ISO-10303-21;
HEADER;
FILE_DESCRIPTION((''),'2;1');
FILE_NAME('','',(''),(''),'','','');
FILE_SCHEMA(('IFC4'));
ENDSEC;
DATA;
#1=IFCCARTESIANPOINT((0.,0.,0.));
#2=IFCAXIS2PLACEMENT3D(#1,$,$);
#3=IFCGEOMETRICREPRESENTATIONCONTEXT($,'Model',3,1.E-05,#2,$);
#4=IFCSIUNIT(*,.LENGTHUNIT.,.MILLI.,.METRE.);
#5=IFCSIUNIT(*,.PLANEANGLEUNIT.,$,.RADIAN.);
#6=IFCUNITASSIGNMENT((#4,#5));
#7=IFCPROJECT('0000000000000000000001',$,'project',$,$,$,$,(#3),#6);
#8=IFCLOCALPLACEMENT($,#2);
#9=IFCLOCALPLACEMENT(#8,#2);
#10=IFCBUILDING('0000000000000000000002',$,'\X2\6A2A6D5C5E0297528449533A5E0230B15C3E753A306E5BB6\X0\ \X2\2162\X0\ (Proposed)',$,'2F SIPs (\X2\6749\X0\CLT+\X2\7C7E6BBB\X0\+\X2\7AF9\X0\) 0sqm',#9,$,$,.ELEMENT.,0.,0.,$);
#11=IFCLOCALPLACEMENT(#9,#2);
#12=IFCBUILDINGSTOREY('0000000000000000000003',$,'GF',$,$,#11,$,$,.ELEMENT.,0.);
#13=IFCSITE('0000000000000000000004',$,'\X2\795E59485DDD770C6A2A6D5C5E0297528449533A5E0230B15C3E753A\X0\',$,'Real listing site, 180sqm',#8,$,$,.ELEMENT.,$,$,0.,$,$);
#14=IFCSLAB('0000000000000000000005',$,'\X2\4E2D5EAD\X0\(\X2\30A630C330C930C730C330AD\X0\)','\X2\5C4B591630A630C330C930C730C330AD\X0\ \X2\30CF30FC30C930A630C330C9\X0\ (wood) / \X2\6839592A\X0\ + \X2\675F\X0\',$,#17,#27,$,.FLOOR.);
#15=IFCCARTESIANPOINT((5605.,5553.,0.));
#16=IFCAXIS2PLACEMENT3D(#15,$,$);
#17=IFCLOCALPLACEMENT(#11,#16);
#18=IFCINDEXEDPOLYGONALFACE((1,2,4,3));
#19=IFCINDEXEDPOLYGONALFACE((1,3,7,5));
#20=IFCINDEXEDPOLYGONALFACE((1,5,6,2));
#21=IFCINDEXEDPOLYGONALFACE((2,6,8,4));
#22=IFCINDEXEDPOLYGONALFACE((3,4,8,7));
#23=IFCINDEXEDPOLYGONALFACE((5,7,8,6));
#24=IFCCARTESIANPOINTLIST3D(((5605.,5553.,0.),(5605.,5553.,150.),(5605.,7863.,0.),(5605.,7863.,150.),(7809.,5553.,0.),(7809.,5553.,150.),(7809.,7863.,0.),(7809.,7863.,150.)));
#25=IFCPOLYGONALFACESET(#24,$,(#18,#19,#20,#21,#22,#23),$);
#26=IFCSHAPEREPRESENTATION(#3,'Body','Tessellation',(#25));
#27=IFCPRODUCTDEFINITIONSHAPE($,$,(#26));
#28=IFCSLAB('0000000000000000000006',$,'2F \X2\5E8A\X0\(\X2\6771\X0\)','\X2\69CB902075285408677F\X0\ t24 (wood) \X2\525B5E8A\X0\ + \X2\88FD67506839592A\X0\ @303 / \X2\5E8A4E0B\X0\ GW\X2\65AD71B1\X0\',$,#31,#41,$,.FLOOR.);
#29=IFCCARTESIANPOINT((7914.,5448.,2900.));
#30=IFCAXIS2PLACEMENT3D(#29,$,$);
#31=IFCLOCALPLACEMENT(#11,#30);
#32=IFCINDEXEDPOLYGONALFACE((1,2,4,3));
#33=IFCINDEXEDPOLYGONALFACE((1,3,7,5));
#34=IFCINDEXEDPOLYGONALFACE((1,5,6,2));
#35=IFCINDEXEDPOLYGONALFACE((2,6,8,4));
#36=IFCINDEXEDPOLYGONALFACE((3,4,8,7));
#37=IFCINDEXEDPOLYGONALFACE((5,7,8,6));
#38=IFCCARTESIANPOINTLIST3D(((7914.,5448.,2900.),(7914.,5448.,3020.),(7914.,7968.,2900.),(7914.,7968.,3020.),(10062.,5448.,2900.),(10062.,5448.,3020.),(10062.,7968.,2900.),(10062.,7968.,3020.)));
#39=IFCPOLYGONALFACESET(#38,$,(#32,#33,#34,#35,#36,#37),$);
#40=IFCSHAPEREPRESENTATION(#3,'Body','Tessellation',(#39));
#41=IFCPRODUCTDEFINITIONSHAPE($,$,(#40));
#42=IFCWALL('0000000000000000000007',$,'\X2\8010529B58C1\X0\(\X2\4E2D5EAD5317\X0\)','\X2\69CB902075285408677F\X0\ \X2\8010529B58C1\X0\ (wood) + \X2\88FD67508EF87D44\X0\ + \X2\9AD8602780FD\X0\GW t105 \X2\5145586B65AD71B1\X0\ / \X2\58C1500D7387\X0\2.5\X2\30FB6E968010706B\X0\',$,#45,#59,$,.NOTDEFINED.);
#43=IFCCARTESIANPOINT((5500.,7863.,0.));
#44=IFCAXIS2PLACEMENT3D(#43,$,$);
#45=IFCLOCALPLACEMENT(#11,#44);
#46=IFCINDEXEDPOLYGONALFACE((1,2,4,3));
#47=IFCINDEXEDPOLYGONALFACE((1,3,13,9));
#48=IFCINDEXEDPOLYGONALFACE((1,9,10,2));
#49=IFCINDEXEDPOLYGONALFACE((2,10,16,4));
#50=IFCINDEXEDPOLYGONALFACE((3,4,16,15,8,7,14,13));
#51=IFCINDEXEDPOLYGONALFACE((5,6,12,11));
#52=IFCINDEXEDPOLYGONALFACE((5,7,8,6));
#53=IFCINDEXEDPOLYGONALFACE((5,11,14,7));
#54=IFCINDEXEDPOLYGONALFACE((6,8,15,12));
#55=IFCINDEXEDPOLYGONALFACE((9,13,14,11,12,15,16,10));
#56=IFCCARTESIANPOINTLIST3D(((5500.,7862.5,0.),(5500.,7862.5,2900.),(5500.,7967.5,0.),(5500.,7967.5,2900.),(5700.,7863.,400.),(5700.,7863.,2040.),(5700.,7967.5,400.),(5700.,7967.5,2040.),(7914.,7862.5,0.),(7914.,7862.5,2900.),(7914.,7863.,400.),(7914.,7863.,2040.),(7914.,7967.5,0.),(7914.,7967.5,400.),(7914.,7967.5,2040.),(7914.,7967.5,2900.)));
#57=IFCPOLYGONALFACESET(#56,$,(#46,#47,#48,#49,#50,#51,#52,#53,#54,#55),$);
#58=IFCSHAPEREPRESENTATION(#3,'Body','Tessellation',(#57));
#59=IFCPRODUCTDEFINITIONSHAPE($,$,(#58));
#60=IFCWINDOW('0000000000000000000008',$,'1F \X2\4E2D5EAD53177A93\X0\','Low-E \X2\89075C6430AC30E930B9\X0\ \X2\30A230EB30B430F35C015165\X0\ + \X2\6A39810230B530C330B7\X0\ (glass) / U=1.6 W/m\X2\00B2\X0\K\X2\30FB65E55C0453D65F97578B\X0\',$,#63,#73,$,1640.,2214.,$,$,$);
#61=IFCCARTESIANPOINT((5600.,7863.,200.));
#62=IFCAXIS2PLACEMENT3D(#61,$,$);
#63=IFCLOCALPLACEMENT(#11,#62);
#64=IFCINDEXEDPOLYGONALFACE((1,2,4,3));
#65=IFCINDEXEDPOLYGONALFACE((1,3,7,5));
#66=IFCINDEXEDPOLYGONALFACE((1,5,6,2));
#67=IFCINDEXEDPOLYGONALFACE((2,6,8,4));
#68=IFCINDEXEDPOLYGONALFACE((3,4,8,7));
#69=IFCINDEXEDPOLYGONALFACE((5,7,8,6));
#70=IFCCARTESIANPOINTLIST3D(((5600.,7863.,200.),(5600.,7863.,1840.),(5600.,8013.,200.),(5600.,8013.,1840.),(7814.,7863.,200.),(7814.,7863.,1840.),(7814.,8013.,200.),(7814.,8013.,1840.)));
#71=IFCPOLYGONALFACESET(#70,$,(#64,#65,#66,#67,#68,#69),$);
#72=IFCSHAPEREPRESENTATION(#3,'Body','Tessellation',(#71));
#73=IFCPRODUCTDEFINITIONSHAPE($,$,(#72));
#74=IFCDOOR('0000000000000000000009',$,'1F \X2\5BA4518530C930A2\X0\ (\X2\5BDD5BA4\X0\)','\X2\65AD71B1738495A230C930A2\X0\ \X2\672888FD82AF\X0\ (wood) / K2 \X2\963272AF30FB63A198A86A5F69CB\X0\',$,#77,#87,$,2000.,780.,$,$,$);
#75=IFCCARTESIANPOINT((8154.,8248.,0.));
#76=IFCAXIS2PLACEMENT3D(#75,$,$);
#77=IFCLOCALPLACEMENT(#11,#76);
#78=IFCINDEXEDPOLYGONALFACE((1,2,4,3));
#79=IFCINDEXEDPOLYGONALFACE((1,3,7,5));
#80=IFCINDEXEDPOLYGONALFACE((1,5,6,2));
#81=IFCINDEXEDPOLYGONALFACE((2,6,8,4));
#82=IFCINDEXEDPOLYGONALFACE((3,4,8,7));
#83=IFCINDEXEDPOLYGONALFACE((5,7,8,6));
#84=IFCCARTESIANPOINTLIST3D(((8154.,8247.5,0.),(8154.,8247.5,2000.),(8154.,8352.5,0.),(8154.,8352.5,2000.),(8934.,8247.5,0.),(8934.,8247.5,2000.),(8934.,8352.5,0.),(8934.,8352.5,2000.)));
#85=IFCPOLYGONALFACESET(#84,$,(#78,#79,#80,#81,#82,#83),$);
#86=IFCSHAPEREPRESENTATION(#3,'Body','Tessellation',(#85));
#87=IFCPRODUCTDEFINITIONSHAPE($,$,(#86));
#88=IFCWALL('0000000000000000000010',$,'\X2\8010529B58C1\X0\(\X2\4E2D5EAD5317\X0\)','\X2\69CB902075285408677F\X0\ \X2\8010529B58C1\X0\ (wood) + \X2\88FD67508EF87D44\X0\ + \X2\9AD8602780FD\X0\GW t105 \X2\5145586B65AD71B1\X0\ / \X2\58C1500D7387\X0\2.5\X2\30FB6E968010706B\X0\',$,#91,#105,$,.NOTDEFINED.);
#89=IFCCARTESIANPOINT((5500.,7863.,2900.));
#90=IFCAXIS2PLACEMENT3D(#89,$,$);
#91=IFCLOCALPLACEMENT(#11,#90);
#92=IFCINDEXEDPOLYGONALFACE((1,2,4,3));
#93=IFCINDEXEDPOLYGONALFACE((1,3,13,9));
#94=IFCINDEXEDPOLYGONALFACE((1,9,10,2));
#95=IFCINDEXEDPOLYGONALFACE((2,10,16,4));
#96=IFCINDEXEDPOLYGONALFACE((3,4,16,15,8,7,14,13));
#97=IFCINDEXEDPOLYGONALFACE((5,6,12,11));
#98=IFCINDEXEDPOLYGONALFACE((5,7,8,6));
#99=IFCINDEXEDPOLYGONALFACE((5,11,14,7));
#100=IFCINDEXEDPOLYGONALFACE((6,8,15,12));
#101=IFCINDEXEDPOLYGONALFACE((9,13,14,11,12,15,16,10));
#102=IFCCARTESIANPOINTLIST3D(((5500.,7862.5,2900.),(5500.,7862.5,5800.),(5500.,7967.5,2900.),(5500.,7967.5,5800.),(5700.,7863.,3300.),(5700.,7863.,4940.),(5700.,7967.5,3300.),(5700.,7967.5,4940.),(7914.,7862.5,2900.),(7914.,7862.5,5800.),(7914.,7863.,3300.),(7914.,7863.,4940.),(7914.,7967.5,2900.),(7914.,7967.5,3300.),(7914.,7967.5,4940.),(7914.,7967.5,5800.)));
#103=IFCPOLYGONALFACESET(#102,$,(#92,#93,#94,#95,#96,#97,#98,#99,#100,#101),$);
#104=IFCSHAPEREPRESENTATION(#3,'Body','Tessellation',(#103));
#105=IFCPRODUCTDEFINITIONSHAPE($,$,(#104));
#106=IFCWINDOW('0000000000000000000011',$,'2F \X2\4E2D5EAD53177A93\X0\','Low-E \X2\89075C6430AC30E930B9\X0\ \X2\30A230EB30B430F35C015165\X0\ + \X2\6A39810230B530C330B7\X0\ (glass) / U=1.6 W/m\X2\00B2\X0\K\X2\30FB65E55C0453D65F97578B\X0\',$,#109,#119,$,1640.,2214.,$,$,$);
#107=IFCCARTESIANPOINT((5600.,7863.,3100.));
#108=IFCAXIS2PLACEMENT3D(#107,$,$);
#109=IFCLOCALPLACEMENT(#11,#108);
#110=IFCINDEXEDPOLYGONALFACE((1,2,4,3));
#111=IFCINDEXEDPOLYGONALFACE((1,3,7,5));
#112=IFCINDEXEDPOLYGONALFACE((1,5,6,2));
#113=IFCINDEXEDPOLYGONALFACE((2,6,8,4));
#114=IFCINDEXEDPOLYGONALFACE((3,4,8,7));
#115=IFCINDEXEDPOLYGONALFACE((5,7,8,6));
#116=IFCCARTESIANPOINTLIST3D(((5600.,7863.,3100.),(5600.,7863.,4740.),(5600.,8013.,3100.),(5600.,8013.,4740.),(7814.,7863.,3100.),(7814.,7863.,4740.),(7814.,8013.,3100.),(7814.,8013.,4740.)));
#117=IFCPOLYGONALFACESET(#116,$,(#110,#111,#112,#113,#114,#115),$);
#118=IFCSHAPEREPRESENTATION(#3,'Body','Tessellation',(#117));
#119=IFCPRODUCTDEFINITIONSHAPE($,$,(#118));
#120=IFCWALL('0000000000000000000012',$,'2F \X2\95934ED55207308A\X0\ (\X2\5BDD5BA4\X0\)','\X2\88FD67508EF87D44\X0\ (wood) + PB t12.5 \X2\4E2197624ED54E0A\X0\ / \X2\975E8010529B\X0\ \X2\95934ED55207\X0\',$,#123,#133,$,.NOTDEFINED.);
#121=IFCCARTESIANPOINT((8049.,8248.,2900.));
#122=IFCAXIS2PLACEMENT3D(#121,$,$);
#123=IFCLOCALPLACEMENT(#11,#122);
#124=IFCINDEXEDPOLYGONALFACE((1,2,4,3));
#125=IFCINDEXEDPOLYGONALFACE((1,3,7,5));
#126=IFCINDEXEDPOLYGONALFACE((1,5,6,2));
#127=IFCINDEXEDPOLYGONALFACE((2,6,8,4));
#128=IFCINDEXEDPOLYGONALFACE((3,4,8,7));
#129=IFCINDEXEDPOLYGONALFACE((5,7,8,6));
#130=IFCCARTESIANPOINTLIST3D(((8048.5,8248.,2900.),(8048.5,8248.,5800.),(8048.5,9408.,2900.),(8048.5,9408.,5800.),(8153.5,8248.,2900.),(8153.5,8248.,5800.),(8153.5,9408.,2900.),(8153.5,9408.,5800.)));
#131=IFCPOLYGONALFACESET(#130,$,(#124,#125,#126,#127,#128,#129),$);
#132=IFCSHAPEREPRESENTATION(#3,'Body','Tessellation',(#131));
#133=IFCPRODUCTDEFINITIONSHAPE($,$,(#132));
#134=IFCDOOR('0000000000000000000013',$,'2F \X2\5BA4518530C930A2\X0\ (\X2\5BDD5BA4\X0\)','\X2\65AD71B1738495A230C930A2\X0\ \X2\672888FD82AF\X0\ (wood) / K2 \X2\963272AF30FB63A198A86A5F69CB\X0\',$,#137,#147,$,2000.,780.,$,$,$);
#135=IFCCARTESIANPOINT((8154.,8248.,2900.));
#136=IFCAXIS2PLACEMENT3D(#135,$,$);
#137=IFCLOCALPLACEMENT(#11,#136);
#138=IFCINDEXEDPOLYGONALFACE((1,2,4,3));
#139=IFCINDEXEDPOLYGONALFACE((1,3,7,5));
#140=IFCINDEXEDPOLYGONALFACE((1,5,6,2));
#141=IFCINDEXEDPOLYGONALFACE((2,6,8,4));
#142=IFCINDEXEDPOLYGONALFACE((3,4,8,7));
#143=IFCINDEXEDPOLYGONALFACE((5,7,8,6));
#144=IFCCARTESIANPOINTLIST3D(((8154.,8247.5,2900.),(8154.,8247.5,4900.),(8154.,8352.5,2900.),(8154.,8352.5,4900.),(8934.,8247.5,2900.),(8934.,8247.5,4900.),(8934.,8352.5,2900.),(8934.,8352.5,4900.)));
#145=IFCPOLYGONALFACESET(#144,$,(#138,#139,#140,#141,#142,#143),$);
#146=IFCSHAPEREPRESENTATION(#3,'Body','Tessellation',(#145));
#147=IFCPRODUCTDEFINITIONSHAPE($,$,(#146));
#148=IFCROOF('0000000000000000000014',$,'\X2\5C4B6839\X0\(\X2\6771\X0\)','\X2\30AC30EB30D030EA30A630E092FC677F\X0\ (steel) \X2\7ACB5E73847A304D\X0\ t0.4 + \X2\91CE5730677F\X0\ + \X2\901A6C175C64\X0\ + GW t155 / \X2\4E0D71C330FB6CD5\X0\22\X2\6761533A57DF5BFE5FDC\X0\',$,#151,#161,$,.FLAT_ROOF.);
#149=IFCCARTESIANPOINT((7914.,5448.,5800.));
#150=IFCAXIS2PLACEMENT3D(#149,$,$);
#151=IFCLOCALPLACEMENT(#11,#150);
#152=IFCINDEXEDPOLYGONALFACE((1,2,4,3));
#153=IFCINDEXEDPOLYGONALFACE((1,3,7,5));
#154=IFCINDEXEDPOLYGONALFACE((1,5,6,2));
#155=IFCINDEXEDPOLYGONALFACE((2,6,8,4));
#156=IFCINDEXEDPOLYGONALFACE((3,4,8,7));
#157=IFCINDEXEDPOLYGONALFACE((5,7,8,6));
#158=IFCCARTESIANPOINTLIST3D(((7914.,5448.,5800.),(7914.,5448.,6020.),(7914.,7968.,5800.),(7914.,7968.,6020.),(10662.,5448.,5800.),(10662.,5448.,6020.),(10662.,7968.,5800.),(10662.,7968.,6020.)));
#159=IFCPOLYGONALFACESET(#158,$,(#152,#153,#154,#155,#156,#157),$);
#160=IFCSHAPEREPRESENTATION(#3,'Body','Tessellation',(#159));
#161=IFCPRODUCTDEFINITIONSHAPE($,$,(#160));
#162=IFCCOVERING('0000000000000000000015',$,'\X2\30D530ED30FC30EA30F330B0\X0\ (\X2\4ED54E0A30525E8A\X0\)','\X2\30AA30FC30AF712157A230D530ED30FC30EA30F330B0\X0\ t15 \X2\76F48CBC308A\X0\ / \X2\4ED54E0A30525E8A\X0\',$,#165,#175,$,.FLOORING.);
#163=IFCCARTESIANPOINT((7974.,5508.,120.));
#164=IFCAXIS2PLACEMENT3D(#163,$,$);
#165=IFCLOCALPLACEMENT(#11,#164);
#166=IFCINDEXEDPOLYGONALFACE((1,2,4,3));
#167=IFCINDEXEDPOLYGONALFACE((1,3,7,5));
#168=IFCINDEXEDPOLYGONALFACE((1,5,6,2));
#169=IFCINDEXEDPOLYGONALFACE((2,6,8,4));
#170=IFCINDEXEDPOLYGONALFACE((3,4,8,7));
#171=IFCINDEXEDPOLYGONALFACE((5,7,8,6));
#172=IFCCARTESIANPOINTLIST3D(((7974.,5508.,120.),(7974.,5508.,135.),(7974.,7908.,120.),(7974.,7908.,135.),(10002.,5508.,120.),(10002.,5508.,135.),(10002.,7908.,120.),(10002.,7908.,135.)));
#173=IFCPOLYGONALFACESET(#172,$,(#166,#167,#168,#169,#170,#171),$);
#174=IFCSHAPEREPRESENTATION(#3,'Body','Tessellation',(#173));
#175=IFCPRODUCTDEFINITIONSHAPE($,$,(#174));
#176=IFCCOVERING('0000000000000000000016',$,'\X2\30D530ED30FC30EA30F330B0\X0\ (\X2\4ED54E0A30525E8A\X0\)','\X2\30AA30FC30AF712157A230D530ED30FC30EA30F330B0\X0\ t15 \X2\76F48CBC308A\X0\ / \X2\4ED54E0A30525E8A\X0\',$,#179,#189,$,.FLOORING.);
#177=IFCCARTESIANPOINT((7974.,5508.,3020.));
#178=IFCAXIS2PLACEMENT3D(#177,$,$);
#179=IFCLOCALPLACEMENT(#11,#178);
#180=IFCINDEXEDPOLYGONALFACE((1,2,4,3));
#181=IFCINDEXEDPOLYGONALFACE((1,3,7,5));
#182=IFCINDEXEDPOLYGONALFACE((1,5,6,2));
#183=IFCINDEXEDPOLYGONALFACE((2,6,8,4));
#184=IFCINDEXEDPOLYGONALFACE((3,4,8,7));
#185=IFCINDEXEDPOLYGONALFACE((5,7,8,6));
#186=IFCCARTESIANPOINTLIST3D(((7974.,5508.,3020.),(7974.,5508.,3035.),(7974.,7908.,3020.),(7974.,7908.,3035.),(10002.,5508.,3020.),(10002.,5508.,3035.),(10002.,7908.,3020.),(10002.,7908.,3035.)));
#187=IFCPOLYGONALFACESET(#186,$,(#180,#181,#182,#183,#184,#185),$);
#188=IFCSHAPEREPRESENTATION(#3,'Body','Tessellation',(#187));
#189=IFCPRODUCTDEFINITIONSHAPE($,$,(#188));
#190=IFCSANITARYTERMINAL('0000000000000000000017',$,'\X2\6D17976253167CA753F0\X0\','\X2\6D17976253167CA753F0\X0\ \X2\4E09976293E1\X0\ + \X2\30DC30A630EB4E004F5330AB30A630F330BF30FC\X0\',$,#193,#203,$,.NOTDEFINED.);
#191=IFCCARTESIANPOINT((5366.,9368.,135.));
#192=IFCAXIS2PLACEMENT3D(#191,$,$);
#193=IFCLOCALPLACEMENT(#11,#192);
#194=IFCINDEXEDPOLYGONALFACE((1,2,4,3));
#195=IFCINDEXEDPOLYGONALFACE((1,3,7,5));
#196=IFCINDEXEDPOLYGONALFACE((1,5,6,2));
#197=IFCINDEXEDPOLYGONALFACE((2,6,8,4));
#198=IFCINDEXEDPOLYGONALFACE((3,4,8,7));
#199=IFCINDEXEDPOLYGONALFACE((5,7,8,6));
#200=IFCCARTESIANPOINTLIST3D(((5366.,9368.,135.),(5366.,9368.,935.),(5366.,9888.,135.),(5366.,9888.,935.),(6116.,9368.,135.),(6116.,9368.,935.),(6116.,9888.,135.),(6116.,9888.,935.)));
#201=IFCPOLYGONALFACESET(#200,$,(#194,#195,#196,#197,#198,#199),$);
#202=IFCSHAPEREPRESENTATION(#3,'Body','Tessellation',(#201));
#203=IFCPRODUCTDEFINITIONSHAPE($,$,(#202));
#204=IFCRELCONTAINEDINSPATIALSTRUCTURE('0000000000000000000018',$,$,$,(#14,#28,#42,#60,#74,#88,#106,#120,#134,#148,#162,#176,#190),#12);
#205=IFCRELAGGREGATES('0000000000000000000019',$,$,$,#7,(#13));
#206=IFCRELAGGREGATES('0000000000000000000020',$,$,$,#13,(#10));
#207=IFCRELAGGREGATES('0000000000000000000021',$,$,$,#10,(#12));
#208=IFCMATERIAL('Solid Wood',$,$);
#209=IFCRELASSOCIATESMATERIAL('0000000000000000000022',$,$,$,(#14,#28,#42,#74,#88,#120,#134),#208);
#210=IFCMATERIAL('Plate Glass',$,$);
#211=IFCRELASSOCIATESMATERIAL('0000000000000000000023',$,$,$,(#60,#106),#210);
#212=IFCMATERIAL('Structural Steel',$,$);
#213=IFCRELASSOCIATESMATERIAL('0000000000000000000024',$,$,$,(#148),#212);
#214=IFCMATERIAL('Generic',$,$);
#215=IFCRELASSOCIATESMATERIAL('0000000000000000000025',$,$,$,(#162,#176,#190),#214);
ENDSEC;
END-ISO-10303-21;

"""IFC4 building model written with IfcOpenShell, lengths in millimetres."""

from ifc_helpers import new_model, si_unit, frame, frame_2d, origin, place, context, project, spatial, rectangle, extrude, material, element, fill, save


model = new_model("IFC4")

# Units and contexts
model_context = context("Model", 3, precision=1e-05, world=origin())
ifc_project = project(units=[si_unit("LENGTHUNIT", "METRE", prefix="MILLI"), si_unit("PLANEANGLEUNIT", "RADIAN")], contexts=[model_context])

# Site, building, storey
site_placement = place(None, origin())
site = spatial("IfcSite", under=ifc_project, at=site_placement, Name="神奈川県横浜市青葉区市ケ尾町", ObjectType="Real listing site, 180sqm", CompositionType="ELEMENT", RefElevation=0.0)
building_placement = place(site_placement, origin())
building = spatial("IfcBuilding", under=site, at=building_placement, Name="横浜市青葉区市ケ尾町の家 Ⅲ (Proposed)", ObjectType="2F SIPs (杉CLT+籾殻+竹) 0sqm", CompositionType="ELEMENT", ElevationOfRefHeight=0.0, ElevationOfTerrain=0.0)
storey_placement = place(building_placement, origin())
storey = spatial("IfcBuildingStorey", under=building, at=storey_placement, Name="GF", CompositionType="ELEMENT", Elevation=0.0)

# Slabs
ifc_material_1 = material(Name="Solid Wood")
slab_1_placement = place(storey_placement, frame((5605.0, 5553.0, 0.0)))
element("IfcSlab", 1, at=slab_1_placement, inside=storey, material=ifc_material_1, Name="中庭(ウッドデッキ)", Description="屋外ウッドデッキ ハードウッド (wood) / 根太 + 束", PredefinedType="FLOOR", context=model_context, shape_type="SweptSolid", body=[
    extrude(rectangle(XDim=2204.0, YDim=2310.0, at=frame_2d((1102.0, 1155.0))), frame((5605.0, 5553.0, 0.0)), (0.0, 0.0, 1.0), 150.0),
])
slab_2_placement = place(storey_placement, frame((7914.0, 5448.0, 2900.0)))
element("IfcSlab", 2, at=slab_2_placement, inside=storey, material=ifc_material_1, Name="2F 床(東)", Description="構造用合板 t24 (wood) 剛床 + 製材根太 @303 / 床下 GW断熱", PredefinedType="FLOOR", context=model_context, shape_type="SweptSolid", body=[
    extrude(rectangle(XDim=2148.0, YDim=2520.0, at=frame_2d((1074.0, 1260.0))), frame((7914.0, 5448.0, 2900.0)), (0.0, 0.0, 1.0), 120.0),
])

# Wall, opening, window
wall_1_placement = place(storey_placement, frame((5500.0, 7863.0, 0.0)))
wall_1 = element("IfcWall", 3, at=wall_1_placement, inside=storey, material=ifc_material_1, Name="耐力壁(中庭北)", Description="構造用合板 耐力壁 (wood) + 製材軸組 + 高性能GW t105 充填断熱 / 壁倍率2.5・準耐火", PredefinedType="NOTDEFINED", context=model_context, shape_type="SweptSolid", body=[
    extrude(rectangle(XDim=2414.0, YDim=105.0, at=frame_2d((1207.0, 52.0))), frame((5500.0, 7863.0, 0.0)), (0.0, 0.0, 1.0), 2900.0),
])
opening_1_placement = place(storey_placement, frame((5600.0, 7863.0, 200.0)))
opening_1 = element("IfcOpeningElement", 4, at=opening_1_placement, cuts=wall_1, PredefinedType="NOTDEFINED", context=model_context, shape_type="SweptSolid", body=[
    extrude(rectangle(XDim=2214.0, YDim=150.0, at=frame_2d((1107.0, 75.0))), frame((5600.0, 7863.0, 200.0)), (0.0, 0.0, 1.0), 1640.0),
])
ifc_material_2 = material(Name="Plate Glass")
window_1_placement = place(storey_placement, frame((5600.0, 7863.0, 200.0)))
window_1 = element("IfcWindow", 5, at=window_1_placement, inside=storey, material=ifc_material_2, Name="1F 中庭北窓", Description="Low-E 複層ガラス アルゴン封入 + 樹脂サッシ (glass) / U=1.6 W/m²K・日射取得型", OverallHeight=1640.0, OverallWidth=2214.0, context=model_context, shape_type="SweptSolid", body=[
    extrude(rectangle(XDim=2214.0, YDim=150.0, at=frame_2d((1107.0, 75.0))), frame((5600.0, 7863.0, 200.0)), (0.0, 0.0, 1.0), 1640.0),
])
fill(opening_1, window_1)

# Door
door_1_placement = place(storey_placement, frame((8154.0, 8248.0, 0.0)))
element("IfcDoor", 6, at=door_1_placement, inside=storey, material=ifc_material_1, Name="1F 室内ドア (寝室)", Description="断熱玄関ドア 木製芯 (wood) / K2 防犯・採風機構", OverallHeight=2000.0, OverallWidth=780.0, context=model_context, shape_type="SweptSolid", body=[
    extrude(rectangle(XDim=780.0, YDim=105.0, at=frame_2d((390.0, 52.0))), frame((8154.0, 8248.0, 0.0)), (0.0, 0.0, 1.0), 2000.0),
])

# Wall, opening, window
wall_2_placement = place(storey_placement, frame((5500.0, 7863.0, 2900.0)))
wall_2 = element("IfcWall", 7, at=wall_2_placement, inside=storey, material=ifc_material_1, Name="耐力壁(中庭北)", Description="構造用合板 耐力壁 (wood) + 製材軸組 + 高性能GW t105 充填断熱 / 壁倍率2.5・準耐火", PredefinedType="NOTDEFINED", context=model_context, shape_type="SweptSolid", body=[
    extrude(rectangle(XDim=2414.0, YDim=105.0, at=frame_2d((1207.0, 52.0))), frame((5500.0, 7863.0, 2900.0)), (0.0, 0.0, 1.0), 2900.0),
])
opening_2_placement = place(storey_placement, frame((5600.0, 7863.0, 3100.0)))
opening_2 = element("IfcOpeningElement", 8, at=opening_2_placement, cuts=wall_2, PredefinedType="NOTDEFINED", context=model_context, shape_type="SweptSolid", body=[
    extrude(rectangle(XDim=2214.0, YDim=150.0, at=frame_2d((1107.0, 75.0))), frame((5600.0, 7863.0, 3100.0)), (0.0, 0.0, 1.0), 1640.0),
])
window_2_placement = place(storey_placement, frame((5600.0, 7863.0, 3100.0)))
window_2 = element("IfcWindow", 9, at=window_2_placement, inside=storey, material=ifc_material_2, Name="2F 中庭北窓", Description="Low-E 複層ガラス アルゴン封入 + 樹脂サッシ (glass) / U=1.6 W/m²K・日射取得型", OverallHeight=1640.0, OverallWidth=2214.0, context=model_context, shape_type="SweptSolid", body=[
    extrude(rectangle(XDim=2214.0, YDim=150.0, at=frame_2d((1107.0, 75.0))), frame((5600.0, 7863.0, 3100.0)), (0.0, 0.0, 1.0), 1640.0),
])
fill(opening_2, window_2)

# Wall
wall_3_placement = place(storey_placement, frame((8049.0, 8248.0, 2900.0)))
element("IfcWall", 10, at=wall_3_placement, inside=storey, material=ifc_material_1, Name="2F 間仕切り (寝室)", Description="製材軸組 (wood) + PB t12.5 両面仕上 / 非耐力 間仕切", PredefinedType="NOTDEFINED", context=model_context, shape_type="SweptSolid", body=[
    extrude(rectangle(XDim=105.0, YDim=1160.0, at=frame_2d((52.0, 580.0))), frame((8049.0, 8248.0, 2900.0)), (0.0, 0.0, 1.0), 2900.0),
])

# Door
door_2_placement = place(storey_placement, frame((8154.0, 8248.0, 2900.0)))
element("IfcDoor", 11, at=door_2_placement, inside=storey, material=ifc_material_1, Name="2F 室内ドア (寝室)", Description="断熱玄関ドア 木製芯 (wood) / K2 防犯・採風機構", OverallHeight=2000.0, OverallWidth=780.0, context=model_context, shape_type="SweptSolid", body=[
    extrude(rectangle(XDim=780.0, YDim=105.0, at=frame_2d((390.0, 52.0))), frame((8154.0, 8248.0, 2900.0)), (0.0, 0.0, 1.0), 2000.0),
])

# Roof
ifc_material_3 = material(Name="Structural Steel")
for number, where, name in (
    (12, (7914.0, 5448.0, 5800.0), "屋根(東)"),
):
    element("IfcRoof", number, at=place(storey_placement, frame(where)), inside=storey, material=ifc_material_3, Name=name, Description="ガルバリウム鋼板 (steel) 立平葺き t0.4 + 野地板 + 通気層 + GW t155 / 不燃・法22条区域対応", PredefinedType="FLAT_ROOF", context=model_context, shape_type="SweptSolid", body=[
        extrude(rectangle(XDim=2748.0, YDim=2520.0, at=frame_2d((1374.0, 1260.0))), frame((7914.0, 5448.0, 5800.0)), (0.0, 0.0, 1.0), 220.0),
    ])

# Coverings
ifc_material_4 = material(Name="Generic")
covering_1_placement = place(storey_placement, frame((7974.0, 5508.0, 120.0)))
element("IfcCovering", 13, at=covering_1_placement, inside=storey, material=ifc_material_4, Name="フローリング (仕上げ床)", Description="オーク無垢フローリング t15 直貼り / 仕上げ床", PredefinedType="FLOORING", context=model_context, shape_type="SweptSolid", body=[
    extrude(rectangle(XDim=2028.0, YDim=2400.0, at=frame_2d((1014.0, 1200.0))), frame((7974.0, 5508.0, 120.0)), (0.0, 0.0, 1.0), 15.0),
])
covering_2_placement = place(storey_placement, frame((7974.0, 5508.0, 3020.0)))
element("IfcCovering", 14, at=covering_2_placement, inside=storey, material=ifc_material_4, Name="フローリング (仕上げ床)", Description="オーク無垢フローリング t15 直貼り / 仕上げ床", PredefinedType="FLOORING", context=model_context, shape_type="SweptSolid", body=[
    extrude(rectangle(XDim=2028.0, YDim=2400.0, at=frame_2d((1014.0, 1200.0))), frame((7974.0, 5508.0, 3020.0)), (0.0, 0.0, 1.0), 15.0),
])

# Sanitary terminal
sanitary_terminal_1_placement = place(storey_placement, frame((5366.0, 9368.0, 135.0)))
element("IfcSanitaryTerminal", 15, at=sanitary_terminal_1_placement, inside=storey, material=ifc_material_4, Name="洗面化粧台", Description="洗面化粧台 三面鏡 + ボウル一体カウンター", PredefinedType="NOTDEFINED", context=model_context, shape_type="SweptSolid", body=[
    extrude(rectangle(XDim=750.0, YDim=520.0, at=frame_2d((375.0, 260.0))), frame((5366.0, 9368.0, 135.0)), (0.0, 0.0, 1.0), 800.0),
])

save(model, "model.ifc")
